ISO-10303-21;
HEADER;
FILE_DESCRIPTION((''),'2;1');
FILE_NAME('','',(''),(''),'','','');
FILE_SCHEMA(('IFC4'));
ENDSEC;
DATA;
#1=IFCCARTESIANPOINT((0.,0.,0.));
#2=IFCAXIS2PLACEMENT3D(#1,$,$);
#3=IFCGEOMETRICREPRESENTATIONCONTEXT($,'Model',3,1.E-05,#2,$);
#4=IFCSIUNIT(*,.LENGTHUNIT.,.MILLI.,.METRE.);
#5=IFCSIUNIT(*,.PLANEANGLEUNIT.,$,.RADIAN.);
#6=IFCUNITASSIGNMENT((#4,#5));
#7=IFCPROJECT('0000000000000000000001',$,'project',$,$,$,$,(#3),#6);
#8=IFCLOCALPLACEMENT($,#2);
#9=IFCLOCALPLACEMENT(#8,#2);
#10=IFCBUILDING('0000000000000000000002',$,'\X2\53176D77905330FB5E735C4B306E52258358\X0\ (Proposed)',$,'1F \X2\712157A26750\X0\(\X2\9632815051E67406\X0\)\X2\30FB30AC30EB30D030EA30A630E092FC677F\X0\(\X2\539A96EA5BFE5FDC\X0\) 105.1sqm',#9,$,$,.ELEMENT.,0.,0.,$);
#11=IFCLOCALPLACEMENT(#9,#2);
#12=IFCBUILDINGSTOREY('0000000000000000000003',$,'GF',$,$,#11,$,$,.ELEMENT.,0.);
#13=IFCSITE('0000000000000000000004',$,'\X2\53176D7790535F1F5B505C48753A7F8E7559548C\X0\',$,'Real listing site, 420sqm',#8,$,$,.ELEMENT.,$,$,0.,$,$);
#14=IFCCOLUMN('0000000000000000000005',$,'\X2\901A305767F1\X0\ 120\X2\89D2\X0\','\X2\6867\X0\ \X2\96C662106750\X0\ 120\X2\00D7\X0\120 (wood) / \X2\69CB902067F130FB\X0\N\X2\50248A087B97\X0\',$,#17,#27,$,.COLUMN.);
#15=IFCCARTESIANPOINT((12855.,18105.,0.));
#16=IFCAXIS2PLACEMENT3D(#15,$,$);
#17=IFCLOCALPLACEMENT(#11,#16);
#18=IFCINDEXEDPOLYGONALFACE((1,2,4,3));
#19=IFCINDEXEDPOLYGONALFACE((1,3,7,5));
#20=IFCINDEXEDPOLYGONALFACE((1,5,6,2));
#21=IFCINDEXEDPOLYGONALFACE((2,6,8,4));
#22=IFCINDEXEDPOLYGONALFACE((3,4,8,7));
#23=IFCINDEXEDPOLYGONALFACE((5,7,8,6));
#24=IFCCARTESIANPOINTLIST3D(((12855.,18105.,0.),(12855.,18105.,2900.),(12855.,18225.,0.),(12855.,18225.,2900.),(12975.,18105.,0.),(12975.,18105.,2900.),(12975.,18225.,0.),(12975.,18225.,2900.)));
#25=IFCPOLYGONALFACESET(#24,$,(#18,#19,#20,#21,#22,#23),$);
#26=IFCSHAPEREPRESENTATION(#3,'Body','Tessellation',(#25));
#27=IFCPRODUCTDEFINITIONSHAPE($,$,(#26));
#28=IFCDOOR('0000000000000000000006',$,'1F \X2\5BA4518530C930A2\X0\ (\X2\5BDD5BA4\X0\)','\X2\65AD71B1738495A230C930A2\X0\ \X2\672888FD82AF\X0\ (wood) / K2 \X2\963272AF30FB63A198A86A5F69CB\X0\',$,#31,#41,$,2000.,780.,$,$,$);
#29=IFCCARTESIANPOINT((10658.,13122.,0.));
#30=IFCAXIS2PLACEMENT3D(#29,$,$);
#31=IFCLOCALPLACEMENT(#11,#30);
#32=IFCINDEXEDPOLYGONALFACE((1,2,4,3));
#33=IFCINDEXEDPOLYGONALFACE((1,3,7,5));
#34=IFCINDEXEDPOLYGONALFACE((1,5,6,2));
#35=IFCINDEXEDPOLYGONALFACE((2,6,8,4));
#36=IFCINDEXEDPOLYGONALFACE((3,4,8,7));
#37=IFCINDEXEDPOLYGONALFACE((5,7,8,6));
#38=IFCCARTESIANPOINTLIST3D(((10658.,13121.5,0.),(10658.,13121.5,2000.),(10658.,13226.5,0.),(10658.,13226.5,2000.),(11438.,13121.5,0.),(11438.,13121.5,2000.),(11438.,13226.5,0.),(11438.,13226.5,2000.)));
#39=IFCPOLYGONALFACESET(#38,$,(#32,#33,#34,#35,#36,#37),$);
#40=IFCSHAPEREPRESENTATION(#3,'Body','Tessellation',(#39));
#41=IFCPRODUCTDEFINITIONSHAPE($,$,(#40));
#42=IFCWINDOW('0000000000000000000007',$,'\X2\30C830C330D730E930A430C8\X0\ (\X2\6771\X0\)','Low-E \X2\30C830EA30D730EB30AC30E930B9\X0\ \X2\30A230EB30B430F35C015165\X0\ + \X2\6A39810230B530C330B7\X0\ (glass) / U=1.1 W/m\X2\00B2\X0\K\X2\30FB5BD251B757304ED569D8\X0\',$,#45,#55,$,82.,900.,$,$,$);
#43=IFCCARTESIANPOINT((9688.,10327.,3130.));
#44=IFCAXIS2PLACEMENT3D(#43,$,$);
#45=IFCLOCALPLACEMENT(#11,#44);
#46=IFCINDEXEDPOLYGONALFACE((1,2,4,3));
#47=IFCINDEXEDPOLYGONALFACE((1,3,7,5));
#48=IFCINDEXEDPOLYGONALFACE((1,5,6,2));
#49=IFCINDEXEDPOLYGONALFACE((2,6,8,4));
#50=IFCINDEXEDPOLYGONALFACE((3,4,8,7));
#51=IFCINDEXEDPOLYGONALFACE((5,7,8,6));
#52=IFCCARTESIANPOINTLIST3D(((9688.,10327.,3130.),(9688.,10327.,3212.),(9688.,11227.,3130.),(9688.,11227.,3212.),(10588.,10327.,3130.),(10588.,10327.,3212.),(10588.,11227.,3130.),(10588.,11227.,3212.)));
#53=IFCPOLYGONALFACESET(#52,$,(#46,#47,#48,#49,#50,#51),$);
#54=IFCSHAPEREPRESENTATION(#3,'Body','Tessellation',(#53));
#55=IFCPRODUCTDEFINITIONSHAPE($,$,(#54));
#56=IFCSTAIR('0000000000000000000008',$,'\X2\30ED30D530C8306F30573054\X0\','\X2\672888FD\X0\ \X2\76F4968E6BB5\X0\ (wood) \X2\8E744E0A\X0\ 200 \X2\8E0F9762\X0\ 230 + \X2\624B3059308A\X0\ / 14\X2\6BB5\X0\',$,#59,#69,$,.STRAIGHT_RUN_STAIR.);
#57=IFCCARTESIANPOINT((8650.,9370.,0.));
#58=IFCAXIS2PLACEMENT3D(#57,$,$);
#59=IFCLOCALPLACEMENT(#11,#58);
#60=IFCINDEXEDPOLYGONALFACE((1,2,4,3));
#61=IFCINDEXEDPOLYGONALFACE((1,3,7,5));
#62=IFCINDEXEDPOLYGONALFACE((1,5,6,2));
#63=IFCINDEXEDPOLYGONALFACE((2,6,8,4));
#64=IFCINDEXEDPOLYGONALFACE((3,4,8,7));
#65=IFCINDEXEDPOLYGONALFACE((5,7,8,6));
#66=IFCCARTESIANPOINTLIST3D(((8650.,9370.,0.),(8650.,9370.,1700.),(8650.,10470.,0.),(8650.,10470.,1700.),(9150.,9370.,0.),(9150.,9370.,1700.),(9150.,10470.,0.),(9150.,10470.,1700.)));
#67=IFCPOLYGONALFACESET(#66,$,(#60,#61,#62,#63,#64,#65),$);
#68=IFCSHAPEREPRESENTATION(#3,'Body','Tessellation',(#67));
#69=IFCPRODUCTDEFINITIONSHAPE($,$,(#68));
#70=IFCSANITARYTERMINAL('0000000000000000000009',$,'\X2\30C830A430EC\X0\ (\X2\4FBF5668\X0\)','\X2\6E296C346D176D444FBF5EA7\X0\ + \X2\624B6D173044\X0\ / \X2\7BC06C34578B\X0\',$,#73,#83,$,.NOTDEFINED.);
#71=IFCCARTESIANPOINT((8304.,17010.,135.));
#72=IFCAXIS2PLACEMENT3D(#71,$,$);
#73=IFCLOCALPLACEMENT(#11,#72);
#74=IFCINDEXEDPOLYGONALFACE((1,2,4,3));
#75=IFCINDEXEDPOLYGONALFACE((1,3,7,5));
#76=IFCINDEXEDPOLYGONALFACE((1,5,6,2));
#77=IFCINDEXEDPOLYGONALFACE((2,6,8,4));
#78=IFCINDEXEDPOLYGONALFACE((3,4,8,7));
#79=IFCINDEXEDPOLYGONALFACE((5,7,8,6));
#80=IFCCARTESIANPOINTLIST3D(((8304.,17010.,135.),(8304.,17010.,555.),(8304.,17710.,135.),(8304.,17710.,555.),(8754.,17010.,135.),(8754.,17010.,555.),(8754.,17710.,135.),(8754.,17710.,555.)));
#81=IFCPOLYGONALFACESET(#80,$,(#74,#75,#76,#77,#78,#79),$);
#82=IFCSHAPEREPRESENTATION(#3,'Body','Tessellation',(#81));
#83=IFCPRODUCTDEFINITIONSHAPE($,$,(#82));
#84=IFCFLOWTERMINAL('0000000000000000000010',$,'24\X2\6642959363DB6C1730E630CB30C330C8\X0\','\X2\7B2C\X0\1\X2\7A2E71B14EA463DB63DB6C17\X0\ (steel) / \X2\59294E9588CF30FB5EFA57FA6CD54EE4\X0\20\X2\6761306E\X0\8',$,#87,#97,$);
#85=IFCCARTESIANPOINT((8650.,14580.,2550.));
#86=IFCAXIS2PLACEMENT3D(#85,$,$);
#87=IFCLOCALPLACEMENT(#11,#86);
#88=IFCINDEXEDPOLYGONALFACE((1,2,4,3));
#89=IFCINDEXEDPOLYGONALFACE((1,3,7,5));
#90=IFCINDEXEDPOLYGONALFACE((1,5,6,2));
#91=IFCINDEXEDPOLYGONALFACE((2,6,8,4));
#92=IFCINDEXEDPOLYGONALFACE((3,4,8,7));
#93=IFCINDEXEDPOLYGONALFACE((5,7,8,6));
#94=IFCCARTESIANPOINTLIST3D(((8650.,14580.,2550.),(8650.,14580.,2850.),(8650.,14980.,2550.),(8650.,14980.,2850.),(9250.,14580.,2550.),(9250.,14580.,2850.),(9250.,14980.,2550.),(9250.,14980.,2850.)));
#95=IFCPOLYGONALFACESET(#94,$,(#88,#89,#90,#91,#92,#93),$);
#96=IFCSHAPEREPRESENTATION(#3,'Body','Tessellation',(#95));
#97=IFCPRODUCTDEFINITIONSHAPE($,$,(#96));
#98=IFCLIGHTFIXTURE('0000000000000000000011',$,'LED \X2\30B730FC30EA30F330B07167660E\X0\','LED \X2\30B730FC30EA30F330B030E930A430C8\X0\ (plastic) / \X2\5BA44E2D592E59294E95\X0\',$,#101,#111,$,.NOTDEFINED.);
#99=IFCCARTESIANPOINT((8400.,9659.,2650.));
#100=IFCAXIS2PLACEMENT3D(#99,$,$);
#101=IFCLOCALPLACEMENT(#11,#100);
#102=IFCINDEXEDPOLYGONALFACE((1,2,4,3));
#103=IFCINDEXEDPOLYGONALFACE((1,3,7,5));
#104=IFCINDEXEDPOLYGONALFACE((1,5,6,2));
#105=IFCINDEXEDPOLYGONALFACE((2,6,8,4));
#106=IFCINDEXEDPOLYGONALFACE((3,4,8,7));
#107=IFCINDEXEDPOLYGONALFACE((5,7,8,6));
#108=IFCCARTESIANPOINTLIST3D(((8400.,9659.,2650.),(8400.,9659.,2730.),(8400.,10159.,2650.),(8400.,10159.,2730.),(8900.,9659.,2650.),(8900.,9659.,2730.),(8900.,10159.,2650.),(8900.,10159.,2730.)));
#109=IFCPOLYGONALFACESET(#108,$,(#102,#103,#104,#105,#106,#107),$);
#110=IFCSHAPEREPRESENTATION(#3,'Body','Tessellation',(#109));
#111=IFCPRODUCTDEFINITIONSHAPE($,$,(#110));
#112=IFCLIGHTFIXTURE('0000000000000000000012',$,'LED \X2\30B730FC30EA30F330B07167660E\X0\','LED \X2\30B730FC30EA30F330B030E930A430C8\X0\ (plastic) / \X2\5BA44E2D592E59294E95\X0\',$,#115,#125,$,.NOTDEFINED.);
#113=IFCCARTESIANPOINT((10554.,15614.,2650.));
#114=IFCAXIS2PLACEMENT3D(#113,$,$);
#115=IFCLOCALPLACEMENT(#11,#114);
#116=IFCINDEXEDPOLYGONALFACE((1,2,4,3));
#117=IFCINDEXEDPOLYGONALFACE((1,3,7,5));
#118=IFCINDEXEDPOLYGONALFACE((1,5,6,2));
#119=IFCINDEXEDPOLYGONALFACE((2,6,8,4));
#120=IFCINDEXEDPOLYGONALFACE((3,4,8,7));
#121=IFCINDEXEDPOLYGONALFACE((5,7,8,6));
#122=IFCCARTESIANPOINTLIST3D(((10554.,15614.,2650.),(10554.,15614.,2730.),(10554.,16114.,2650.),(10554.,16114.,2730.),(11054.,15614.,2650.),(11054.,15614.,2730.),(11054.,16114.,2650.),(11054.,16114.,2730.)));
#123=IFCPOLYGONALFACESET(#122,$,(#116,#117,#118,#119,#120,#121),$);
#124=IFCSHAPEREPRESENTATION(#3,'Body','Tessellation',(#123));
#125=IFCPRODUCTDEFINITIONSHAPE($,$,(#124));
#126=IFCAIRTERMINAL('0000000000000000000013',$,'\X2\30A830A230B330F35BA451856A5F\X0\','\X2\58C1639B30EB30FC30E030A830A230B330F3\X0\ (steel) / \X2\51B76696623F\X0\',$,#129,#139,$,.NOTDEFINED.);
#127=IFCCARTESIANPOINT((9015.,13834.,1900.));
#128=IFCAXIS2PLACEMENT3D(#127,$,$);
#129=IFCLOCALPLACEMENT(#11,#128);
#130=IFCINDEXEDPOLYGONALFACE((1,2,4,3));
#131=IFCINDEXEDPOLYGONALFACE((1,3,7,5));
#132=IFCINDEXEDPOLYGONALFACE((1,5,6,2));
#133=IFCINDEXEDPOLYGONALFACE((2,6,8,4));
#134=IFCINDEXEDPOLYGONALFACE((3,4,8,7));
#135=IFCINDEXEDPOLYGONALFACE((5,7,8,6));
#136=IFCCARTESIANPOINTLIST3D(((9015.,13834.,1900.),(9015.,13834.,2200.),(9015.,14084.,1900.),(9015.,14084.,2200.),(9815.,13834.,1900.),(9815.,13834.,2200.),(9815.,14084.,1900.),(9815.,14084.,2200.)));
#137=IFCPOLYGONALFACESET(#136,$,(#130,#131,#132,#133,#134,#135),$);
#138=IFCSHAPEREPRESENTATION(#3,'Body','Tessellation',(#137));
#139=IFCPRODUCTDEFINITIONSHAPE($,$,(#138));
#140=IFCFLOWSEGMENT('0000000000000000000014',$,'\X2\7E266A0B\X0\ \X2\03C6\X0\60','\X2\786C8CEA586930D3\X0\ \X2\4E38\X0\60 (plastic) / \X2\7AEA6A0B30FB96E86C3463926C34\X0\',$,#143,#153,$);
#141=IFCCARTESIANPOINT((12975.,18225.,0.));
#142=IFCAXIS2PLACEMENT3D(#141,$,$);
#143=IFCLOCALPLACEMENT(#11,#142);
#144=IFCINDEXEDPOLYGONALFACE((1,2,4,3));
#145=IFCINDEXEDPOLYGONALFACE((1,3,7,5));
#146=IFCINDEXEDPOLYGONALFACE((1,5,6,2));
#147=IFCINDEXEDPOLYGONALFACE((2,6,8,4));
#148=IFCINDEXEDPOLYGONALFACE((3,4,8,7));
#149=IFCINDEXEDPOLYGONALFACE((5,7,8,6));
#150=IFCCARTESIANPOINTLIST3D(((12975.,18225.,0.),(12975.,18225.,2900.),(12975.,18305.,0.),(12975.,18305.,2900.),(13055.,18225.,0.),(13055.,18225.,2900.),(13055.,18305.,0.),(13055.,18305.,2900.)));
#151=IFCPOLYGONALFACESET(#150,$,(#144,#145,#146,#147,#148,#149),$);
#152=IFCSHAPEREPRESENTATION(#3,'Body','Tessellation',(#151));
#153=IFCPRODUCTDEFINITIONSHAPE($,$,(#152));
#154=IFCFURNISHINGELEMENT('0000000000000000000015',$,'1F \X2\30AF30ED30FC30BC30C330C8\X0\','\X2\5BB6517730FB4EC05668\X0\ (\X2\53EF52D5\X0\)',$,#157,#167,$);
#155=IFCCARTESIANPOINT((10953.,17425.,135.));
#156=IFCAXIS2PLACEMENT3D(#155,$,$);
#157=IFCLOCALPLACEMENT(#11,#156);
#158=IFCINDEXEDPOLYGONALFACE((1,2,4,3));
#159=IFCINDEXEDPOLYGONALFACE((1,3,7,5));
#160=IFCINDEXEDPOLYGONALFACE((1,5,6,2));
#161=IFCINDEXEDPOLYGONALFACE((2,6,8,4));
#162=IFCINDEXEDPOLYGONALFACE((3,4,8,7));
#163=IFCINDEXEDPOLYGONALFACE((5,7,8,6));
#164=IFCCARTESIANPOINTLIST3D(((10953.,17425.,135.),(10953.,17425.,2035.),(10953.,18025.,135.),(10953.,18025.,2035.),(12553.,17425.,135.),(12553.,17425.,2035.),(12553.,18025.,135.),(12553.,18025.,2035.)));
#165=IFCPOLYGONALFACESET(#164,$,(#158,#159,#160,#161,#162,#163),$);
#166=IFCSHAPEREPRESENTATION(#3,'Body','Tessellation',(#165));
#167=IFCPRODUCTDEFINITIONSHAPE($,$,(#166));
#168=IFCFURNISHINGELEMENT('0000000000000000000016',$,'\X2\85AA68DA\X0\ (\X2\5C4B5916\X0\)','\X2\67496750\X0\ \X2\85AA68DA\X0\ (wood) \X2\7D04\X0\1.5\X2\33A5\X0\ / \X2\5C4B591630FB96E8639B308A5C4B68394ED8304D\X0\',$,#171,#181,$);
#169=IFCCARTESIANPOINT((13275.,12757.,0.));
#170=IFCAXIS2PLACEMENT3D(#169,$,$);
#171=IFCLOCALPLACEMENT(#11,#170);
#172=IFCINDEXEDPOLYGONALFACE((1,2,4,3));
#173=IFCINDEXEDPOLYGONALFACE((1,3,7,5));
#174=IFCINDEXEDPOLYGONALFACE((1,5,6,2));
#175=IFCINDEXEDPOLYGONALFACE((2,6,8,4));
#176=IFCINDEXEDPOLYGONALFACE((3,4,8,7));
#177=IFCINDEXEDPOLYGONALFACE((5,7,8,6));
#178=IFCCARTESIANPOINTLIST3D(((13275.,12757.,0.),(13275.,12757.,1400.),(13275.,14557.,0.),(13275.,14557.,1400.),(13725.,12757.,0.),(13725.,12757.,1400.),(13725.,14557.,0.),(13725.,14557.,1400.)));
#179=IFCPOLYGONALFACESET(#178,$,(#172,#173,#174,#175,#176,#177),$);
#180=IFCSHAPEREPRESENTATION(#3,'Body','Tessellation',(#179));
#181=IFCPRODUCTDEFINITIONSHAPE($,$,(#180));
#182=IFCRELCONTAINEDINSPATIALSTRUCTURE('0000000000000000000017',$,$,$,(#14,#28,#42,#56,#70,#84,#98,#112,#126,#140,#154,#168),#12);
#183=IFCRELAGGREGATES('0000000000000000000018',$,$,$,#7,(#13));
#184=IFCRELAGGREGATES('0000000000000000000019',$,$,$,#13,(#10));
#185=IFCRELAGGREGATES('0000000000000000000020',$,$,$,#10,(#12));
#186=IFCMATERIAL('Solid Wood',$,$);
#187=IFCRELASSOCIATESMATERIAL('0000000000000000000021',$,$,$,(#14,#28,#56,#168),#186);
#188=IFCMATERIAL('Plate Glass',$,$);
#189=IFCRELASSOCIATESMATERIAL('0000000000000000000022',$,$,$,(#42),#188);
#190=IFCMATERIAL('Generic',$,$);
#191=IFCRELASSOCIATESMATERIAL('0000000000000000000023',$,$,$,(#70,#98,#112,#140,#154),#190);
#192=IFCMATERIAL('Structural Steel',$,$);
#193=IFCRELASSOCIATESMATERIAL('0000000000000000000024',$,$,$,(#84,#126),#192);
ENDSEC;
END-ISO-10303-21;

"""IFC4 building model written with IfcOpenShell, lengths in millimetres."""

from ifc_helpers import new_model, si_unit, frame, frame_2d, origin, place, context, project, spatial, rectangle, extrude, material, element, save


model = new_model("IFC4")

# Units and contexts
model_context = context("Model", 3, precision=1e-05, world=origin())
ifc_project = project(units=[si_unit("LENGTHUNIT", "METRE", prefix="MILLI"), si_unit("PLANEANGLEUNIT", "RADIAN")], contexts=[model_context])

# Site, building, storey
site_placement = place(None, origin())
site = spatial("IfcSite", under=ifc_project, at=site_placement, Name="北海道弟子屈町美留和", ObjectType="Real listing site, 420sqm", CompositionType="ELEMENT", RefElevation=0.0)
building_placement = place(site_placement, origin())
building = spatial("IfcBuilding", under=site, at=building_placement, Name="北海道・平屋の別荘 (Proposed)", ObjectType="1F 無垢材(防腐処理)・ガルバリウム鋼板(厚雪対応) 105.1sqm", CompositionType="ELEMENT", ElevationOfRefHeight=0.0, ElevationOfTerrain=0.0)
storey_placement = place(building_placement, origin())
storey = spatial("IfcBuildingStorey", under=building, at=storey_placement, Name="GF", CompositionType="ELEMENT", Elevation=0.0)

# Column
ifc_material_1 = material(Name="Solid Wood")
column_1_placement = place(storey_placement, frame((12855.0, 18105.0, 0.0)))
element("IfcColumn", 1, at=column_1_placement, inside=storey, material=ifc_material_1, Name="通し柱 120角", Description="桧 集成材 120×120 (wood) / 構造柱・N値計算", PredefinedType="COLUMN", context=model_context, shape_type="SweptSolid", body=[
    extrude(rectangle(XDim=120.0, YDim=120.0, at=frame_2d((60.0, 60.0))), frame((12855.0, 18105.0, 0.0)), (0.0, 0.0, 1.0), 2900.0),
])

# Door
door_placement = place(storey_placement, frame((10658.0, 13122.0, 0.0)))
element("IfcDoor", 2, at=door_placement, inside=storey, material=ifc_material_1, Name="1F 室内ドア (寝室)", Description="断熱玄関ドア 木製芯 (wood) / K2 防犯・採風機構", OverallHeight=2000.0, OverallWidth=780.0, context=model_context, shape_type="SweptSolid", body=[
    extrude(rectangle(XDim=780.0, YDim=105.0, at=frame_2d((390.0, 52.0))), frame((10658.0, 13122.0, 0.0)), (0.0, 0.0, 1.0), 2000.0),
])

# Window
ifc_material_2 = material(Name="Plate Glass")
window_placement = place(storey_placement, frame((9688.0, 10327.0, 3130.0)))
element("IfcWindow", 3, at=window_placement, inside=storey, material=ifc_material_2, Name="トップライト (東)", Description="Low-E トリプルガラス アルゴン封入 + 樹脂サッシ (glass) / U=1.1 W/m²K・寒冷地仕様", OverallHeight=82.0, OverallWidth=900.0, context=model_context, shape_type="SweptSolid", body=[
    extrude(rectangle(XDim=900.0, YDim=900.0, at=frame_2d((450.0, 450.0))), frame((9688.0, 10327.0, 3130.0)), (0.0, 0.0, 1.0), 82.0),
])

# Stair
stair_placement = place(storey_placement, frame((8650.0, 9370.0, 0.0)))
element("IfcStair", 4, at=stair_placement, inside=storey, material=ifc_material_1, Name="ロフトはしご", Description="木製 直階段 (wood) 蹴上 200 踏面 230 + 手すり / 14段", PredefinedType="STRAIGHT_RUN_STAIR", context=model_context, shape_type="SweptSolid", body=[
    extrude(rectangle(XDim=500.0, YDim=1100.0, at=frame_2d((250.0, 550.0))), frame((8650.0, 9370.0, 0.0)), (0.0, 0.0, 1.0), 1700.0),
])

# Sanitary terminal
ifc_material_3 = material(Name="Generic")
sanitary_terminal_placement = place(storey_placement, frame((8304.0, 17010.0, 135.0)))
element("IfcSanitaryTerminal", 5, at=sanitary_terminal_placement, inside=storey, material=ifc_material_3, Name="トイレ (便器)", Description="温水洗浄便座 + 手洗い / 節水型", PredefinedType="NOTDEFINED", context=model_context, shape_type="SweptSolid", body=[
    extrude(rectangle(XDim=450.0, YDim=700.0, at=frame_2d((225.0, 350.0))), frame((8304.0, 17010.0, 135.0)), (0.0, 0.0, 1.0), 420.0),
])

# Flow terminal
ifc_material_4 = material(Name="Structural Steel")
flow_terminal_placement = place(storey_placement, frame((8650.0, 14580.0, 2550.0)))
element("IfcFlowTerminal", 6, at=flow_terminal_placement, inside=storey, material=ifc_material_4, Name="24時間換気ユニット", Description="第1種熱交換換気 (steel) / 天井裏・建基法令20条の8", context=model_context, shape_type="SweptSolid", body=[
    extrude(rectangle(XDim=600.0, YDim=400.0, at=frame_2d((300.0, 200.0))), frame((8650.0, 14580.0, 2550.0)), (0.0, 0.0, 1.0), 300.0),
])

# Light fixtures
light_fixture_1_placement = place(storey_placement, frame((8400.0, 9659.0, 2650.0)))
element("IfcLightFixture", 7, at=light_fixture_1_placement, inside=storey, material=ifc_material_3, Name="LED シーリング照明", Description="LED シーリングライト (plastic) / 室中央天井", PredefinedType="NOTDEFINED", context=model_context, shape_type="SweptSolid", body=[
    extrude(rectangle(XDim=500.0, YDim=500.0, at=frame_2d((250.0, 250.0))), frame((8400.0, 9659.0, 2650.0)), (0.0, 0.0, 1.0), 80.0),
])
light_fixture_2_placement = place(storey_placement, frame((10554.0, 15614.0, 2650.0)))
element("IfcLightFixture", 8, at=light_fixture_2_placement, inside=storey, material=ifc_material_3, Name="LED シーリング照明", Description="LED シーリングライト (plastic) / 室中央天井", PredefinedType="NOTDEFINED", context=model_context, shape_type="SweptSolid", body=[
    extrude(rectangle(XDim=500.0, YDim=500.0, at=frame_2d((250.0, 250.0))), frame((10554.0, 15614.0, 2650.0)), (0.0, 0.0, 1.0), 80.0),
])

# Air terminal
air_terminal_placement = place(storey_placement, frame((9015.0, 13834.0, 1900.0)))
element("IfcAirTerminal", 9, at=air_terminal_placement, inside=storey, material=ifc_material_4, Name="エアコン室内機", Description="壁掛ルームエアコン (steel) / 冷暖房", PredefinedType="NOTDEFINED", context=model_context, shape_type="SweptSolid", body=[
    extrude(rectangle(XDim=800.0, YDim=250.0, at=frame_2d((400.0, 125.0))), frame((9015.0, 13834.0, 1900.0)), (0.0, 0.0, 1.0), 300.0),
])

# Flow segment
flow_segment_placement = place(storey_placement, frame((12975.0, 18225.0, 0.0)))
element("IfcFlowSegment", 10, at=flow_segment_placement, inside=storey, material=ifc_material_3, Name="縦樋 φ60", Description="硬質塩ビ 丸60 (plastic) / 竪樋・雨水排水", context=model_context, shape_type="SweptSolid", body=[
    extrude(rectangle(XDim=80.0, YDim=80.0, at=frame_2d((40.0, 40.0))), frame((12975.0, 18225.0, 0.0)), (0.0, 0.0, 1.0), 2900.0),
])

# Furnishing elements
furnishing_1_placement = place(storey_placement, frame((10953.0, 17425.0, 135.0)))
element("IfcFurnishingElement", 11, at=furnishing_1_placement, inside=storey, material=ifc_material_3, Name="1F クローゼット", Description="家具・什器 (可動)", context=model_context, shape_type="SweptSolid", body=[
    extrude(rectangle(XDim=1600.0, YDim=600.0, at=frame_2d((800.0, 300.0))), frame((10953.0, 17425.0, 135.0)), (0.0, 0.0, 1.0), 1900.0),
])
furnishing_2_placement = place(storey_placement, frame((13275.0, 12757.0, 0.0)))
element("IfcFurnishingElement", 12, at=furnishing_2_placement, inside=storey, material=ifc_material_1, Name="薪棚 (屋外)", Description="杉材 薪棚 (wood) 約1.5㎥ / 屋外・雨掛り屋根付き", context=model_context, shape_type="SweptSolid", body=[
    extrude(rectangle(XDim=450.0, YDim=1800.0, at=frame_2d((225.0, 900.0))), frame((13275.0, 12757.0, 0.0)), (0.0, 0.0, 1.0), 1400.0),
])

save(model, "model.ifc")
